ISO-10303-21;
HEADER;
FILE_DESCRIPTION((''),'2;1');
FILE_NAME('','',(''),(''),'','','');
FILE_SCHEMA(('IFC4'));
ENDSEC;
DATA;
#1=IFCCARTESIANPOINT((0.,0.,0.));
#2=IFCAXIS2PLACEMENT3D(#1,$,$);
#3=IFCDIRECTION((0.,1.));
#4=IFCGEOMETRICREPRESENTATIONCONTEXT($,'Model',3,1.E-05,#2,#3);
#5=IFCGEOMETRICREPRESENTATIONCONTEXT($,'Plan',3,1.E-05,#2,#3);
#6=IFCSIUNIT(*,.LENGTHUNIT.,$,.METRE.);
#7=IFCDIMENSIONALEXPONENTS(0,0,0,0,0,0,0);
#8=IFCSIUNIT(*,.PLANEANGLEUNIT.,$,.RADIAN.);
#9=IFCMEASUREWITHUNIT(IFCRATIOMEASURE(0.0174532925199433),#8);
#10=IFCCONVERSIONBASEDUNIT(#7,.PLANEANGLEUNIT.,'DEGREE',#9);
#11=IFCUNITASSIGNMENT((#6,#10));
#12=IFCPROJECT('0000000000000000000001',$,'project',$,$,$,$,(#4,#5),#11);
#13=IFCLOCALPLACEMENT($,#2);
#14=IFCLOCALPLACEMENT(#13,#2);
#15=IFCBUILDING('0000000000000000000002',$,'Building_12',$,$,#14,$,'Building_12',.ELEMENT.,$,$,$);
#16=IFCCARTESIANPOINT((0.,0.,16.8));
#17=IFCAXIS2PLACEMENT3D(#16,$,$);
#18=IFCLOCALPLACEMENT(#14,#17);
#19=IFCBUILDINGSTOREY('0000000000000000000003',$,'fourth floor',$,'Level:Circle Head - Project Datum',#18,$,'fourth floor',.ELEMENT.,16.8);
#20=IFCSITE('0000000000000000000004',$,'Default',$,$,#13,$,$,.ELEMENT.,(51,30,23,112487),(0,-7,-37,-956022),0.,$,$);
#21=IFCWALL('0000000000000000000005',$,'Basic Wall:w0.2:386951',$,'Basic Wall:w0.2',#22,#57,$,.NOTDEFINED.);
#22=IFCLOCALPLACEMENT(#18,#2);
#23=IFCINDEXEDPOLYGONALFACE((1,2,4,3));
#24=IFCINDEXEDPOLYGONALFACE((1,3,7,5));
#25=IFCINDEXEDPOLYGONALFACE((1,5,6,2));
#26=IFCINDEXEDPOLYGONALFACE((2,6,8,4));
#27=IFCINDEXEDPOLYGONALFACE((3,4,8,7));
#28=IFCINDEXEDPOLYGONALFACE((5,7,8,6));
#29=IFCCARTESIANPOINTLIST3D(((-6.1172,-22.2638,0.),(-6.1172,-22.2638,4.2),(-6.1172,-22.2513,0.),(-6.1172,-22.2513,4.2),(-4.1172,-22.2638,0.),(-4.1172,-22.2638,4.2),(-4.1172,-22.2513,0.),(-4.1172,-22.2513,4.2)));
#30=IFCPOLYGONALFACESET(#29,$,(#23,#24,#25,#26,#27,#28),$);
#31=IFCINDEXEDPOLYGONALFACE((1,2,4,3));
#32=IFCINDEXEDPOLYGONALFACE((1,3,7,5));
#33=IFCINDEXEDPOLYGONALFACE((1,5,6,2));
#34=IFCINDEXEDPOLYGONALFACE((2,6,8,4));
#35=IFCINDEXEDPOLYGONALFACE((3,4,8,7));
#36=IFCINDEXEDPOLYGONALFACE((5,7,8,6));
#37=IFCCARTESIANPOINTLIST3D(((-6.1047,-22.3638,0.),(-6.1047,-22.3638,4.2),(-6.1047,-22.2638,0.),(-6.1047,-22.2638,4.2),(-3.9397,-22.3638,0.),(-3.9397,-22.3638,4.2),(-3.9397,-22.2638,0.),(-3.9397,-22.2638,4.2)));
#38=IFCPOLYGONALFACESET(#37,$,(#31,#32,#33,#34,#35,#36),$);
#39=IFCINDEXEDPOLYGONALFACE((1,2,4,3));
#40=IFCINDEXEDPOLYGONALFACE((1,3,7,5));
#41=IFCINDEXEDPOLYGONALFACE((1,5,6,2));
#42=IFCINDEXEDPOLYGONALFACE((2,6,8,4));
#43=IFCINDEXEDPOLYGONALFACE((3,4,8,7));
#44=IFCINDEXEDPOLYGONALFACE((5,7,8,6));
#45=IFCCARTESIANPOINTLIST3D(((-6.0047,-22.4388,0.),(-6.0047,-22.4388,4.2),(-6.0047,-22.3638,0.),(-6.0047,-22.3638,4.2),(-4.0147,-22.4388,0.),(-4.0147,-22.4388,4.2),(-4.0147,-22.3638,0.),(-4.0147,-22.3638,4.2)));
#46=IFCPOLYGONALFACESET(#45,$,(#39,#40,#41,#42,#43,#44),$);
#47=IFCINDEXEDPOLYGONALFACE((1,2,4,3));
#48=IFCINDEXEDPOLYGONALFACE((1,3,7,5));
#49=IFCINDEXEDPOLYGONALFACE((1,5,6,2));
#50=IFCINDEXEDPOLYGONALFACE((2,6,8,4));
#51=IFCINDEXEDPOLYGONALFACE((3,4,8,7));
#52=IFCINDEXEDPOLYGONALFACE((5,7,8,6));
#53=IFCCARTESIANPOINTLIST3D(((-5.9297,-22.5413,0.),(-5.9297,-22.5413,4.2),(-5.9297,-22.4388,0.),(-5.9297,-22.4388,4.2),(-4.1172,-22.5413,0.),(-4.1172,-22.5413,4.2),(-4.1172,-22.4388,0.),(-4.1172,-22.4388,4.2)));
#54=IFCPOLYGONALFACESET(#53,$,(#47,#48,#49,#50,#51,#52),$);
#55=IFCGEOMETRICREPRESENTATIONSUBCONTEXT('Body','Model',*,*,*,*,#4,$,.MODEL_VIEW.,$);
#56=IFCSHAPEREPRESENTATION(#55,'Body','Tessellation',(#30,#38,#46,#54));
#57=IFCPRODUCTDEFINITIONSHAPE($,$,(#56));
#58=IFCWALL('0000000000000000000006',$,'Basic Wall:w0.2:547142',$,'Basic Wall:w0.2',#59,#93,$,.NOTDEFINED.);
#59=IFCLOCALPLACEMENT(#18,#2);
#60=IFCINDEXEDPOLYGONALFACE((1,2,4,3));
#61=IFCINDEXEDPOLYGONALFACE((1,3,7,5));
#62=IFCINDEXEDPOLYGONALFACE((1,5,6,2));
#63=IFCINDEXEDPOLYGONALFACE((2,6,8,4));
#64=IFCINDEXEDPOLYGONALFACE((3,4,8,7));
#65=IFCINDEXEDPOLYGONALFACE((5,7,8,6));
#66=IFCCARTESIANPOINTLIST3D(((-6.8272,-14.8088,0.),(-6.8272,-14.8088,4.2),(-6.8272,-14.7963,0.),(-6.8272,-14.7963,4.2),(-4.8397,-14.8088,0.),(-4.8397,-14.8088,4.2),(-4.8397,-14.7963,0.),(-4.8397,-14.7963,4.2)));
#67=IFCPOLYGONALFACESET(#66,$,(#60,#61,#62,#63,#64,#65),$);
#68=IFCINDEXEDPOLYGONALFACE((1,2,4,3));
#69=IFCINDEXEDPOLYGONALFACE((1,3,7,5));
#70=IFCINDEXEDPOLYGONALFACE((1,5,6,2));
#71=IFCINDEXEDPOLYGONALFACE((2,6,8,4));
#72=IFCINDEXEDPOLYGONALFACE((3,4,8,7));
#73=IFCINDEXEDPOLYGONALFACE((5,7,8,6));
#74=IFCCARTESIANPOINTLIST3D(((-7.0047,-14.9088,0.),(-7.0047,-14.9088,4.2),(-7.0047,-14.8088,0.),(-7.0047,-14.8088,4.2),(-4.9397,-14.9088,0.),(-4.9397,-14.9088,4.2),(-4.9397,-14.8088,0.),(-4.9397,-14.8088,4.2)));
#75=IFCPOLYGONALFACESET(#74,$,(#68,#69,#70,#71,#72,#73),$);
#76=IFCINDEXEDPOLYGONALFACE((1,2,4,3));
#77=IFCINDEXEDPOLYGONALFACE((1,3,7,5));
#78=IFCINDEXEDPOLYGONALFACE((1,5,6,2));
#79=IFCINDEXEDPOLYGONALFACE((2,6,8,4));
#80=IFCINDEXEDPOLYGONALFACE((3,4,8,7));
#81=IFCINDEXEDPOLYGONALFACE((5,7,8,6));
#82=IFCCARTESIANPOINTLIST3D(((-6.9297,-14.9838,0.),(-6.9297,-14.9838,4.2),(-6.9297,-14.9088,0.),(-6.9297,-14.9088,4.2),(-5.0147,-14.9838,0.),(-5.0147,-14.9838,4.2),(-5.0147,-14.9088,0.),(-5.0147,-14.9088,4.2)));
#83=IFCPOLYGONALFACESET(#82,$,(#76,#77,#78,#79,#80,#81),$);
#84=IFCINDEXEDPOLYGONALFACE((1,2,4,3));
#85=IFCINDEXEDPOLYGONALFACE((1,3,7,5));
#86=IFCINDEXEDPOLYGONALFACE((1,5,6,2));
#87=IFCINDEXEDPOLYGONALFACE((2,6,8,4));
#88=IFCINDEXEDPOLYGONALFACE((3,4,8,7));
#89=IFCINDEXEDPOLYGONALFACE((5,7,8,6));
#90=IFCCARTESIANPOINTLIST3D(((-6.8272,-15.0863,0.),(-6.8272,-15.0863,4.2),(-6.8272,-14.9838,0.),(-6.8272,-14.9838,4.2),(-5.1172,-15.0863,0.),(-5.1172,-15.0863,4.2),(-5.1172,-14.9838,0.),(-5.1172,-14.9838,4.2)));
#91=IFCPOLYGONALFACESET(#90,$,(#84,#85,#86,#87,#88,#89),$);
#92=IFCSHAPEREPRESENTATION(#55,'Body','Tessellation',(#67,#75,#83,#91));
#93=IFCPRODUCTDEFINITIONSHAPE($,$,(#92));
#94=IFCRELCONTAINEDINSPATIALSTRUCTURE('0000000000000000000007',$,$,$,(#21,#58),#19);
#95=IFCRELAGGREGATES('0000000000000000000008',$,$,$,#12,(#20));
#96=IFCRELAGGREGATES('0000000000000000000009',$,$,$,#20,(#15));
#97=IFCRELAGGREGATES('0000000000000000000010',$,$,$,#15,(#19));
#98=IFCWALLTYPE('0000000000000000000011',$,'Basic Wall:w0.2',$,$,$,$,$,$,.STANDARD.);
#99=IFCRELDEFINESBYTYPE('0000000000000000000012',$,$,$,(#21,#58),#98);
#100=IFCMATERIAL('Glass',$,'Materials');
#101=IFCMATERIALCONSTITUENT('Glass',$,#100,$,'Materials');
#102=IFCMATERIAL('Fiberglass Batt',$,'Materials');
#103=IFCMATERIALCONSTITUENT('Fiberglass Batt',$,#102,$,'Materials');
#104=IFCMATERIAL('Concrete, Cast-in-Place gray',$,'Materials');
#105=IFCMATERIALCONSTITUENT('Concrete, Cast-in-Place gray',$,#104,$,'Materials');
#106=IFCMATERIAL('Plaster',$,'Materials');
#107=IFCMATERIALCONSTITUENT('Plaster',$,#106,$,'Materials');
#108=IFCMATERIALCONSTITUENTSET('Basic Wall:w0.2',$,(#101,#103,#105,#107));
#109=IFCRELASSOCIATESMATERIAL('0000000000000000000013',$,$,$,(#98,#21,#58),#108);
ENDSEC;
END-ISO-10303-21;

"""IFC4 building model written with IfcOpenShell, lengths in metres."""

from ifc_helpers import new_model, entity, si_unit, converted_unit, direction, frame, origin, place, context, subcontext, project, spatial, indexed_curve, outline, extrude, material, constituent, constituent_set, type_object, element, save


model = new_model("IFC4")

# Units and contexts
model_context = context("Model", 3, precision=1e-05, world=origin(), true_north=direction((0.0, 1.0)))
plan_context = context("Plan", 3, precision=1e-05, world=origin(), true_north=direction((0.0, 1.0)))
body_context = subcontext(model_context, "Body", "Model", "MODEL_VIEW")
ifc_project = project(units=[si_unit("LENGTHUNIT", "METRE"), converted_unit("PLANEANGLEUNIT", "DEGREE", entity("IfcRatioMeasure", 0.0174532925199433), si_unit("PLANEANGLEUNIT", "RADIAN"), dimensions=[0, 0, 0, 0, 0, 0, 0])], contexts=[model_context, plan_context])

# Site, building, storey
site_placement = place(None, origin())
site = spatial("IfcSite", under=ifc_project, at=site_placement, Name="Default", CompositionType="ELEMENT", RefLatitude=(51, 30, 23, 112487), RefLongitude=(0, -7, -37, -956022), RefElevation=0.0)
building_placement = place(site_placement, origin())
building = spatial("IfcBuilding", under=site, at=building_placement, Name="Building_12", LongName="Building_12", CompositionType="ELEMENT")
storey_placement = place(building_placement, frame((0.0, 0.0, 16.8)))
storey = spatial("IfcBuildingStorey", under=building, at=storey_placement, Name="fourth floor", ObjectType="Level:Circle Head - Project Datum", LongName="fourth floor", CompositionType="ELEMENT", Elevation=16.8)

# Shared definitions
ifc_material_1 = material(Name="Glass", Category="Materials")
ifc_constituent_1 = constituent(ifc_material_1, Name="Glass", Category="Materials")
ifc_material_2 = material(Name="Fiberglass Batt", Category="Materials")
ifc_constituent_2 = constituent(ifc_material_2, Name="Fiberglass Batt", Category="Materials")
ifc_material_3 = material(Name="Concrete, Cast-in-Place gray", Category="Materials")
ifc_constituent_3 = constituent(ifc_material_3, Name="Concrete, Cast-in-Place gray", Category="Materials")
ifc_material_4 = material(Name="Plaster", Category="Materials")
ifc_constituent_4 = constituent(ifc_material_4, Name="Plaster", Category="Materials")
ifc_constituent_set_1 = constituent_set(constituents=[ifc_constituent_1, ifc_constituent_2, ifc_constituent_3, ifc_constituent_4], Name="Basic Wall:w0.2")
wall_type = type_object("IfcWallType", Name="Basic Wall:w0.2", PredefinedType="STANDARD", material=ifc_constituent_set_1)

# Wall, opening
wall_1_placement = place(storey_placement, frame((-4.1172, -22.3963, 0.0), z_axis=(0.0, 0.0, 1.0), x_axis=(-1.0, 0.0, 0.0)))
wall_1 = element("IfcWall", 1, at=wall_1_placement, inside=storey, type_object=wall_type, material=ifc_constituent_set_1, Name="Basic Wall:w0.2:386951", ObjectType="Basic Wall:w0.2", PredefinedType="NOTDEFINED", context=body_context, shape_type="SweptSolid", body=[
    extrude(outline(indexed_curve([(-0.0063, -1.0), (0.0062, -1.0), (0.0063, 1.0), (-0.0062, 1.0), (-0.0063, -1.0)], self_intersect=False)), frame((1.0, -0.1387, 0.0), z_axis=(0.0, 0.0, 1.0), x_axis=(0.0, 1.0, 0.0)), (0.0, 0.0, 1.0), 4.2),
    extrude(outline(indexed_curve([(-1.0825, -0.05), (1.0825, -0.05), (1.0825, 0.05), (-1.0825, 0.05), (-1.0825, -0.05)], self_intersect=False)), frame((0.905, -0.0825, 0.0)), (0.0, 0.0, 1.0), 4.2),
    extrude(outline(indexed_curve([(-0.995, -0.0375), (0.995, -0.0375), (0.995, 0.0375), (-0.995, 0.0375), (-0.995, -0.0375)], self_intersect=False)), frame((0.8925, 0.005, 0.0)), (0.0, 0.0, 1.0), 4.2),
    extrude(outline(indexed_curve([(-0.0513, -0.9063), (0.0512, -0.9063), (0.0513, 0.9063), (-0.0512, 0.9063), (-0.0513, -0.9063)], self_intersect=False)), frame((0.9063, 0.0938, 0.0), z_axis=(0.0, 0.0, 1.0), x_axis=(0.0, -1.0, 0.0)), (0.0, 0.0, 1.0), 4.2),
])
opening_1_placement = place(wall_1_placement, origin())
element("IfcOpeningElement", 2, at=opening_1_placement, cuts=wall_1, PredefinedType="OPENING", context=body_context, shape_type="SweptSolid", body=[
    extrude(outline(indexed_curve([(-0.145, -1.055), (0.145, -1.055), (0.145, 1.055), (-0.145, 1.055), (-0.145, -1.055)], self_intersect=False)), frame((1.855, 0.145, 1.055), z_axis=(0.0, 1.0, 0.0), x_axis=(-1.0, 0.0, 0.0)), (0.0, 0.0, 1.0), 0.91),
])

# Wall
wall_2_placement = place(storey_placement, frame((-5.1172, -14.9413, 0.0), z_axis=(0.0, 0.0, 1.0), x_axis=(-1.0, 0.0, 0.0)))
element("IfcWall", 3, at=wall_2_placement, inside=storey, type_object=wall_type, material=ifc_constituent_set_1, Name="Basic Wall:w0.2:547142", ObjectType="Basic Wall:w0.2", PredefinedType="NOTDEFINED", context=body_context, shape_type="SweptSolid", body=[
    extrude(outline(indexed_curve([(-0.0063, -0.9938), (0.0062, -0.9938), (0.0063, 0.9938), (-0.0062, 0.9938), (-0.0063, -0.9938)], self_intersect=False)), frame((0.7163, -0.1388, 0.0), z_axis=(0.0, 0.0, 1.0), x_axis=(0.0, 1.0, 0.0)), (0.0, 0.0, 1.0), 4.2),
    extrude(outline(indexed_curve([(-1.0325, -0.05), (1.0325, -0.05), (1.0325, 0.05), (-1.0325, 0.05), (-1.0325, -0.05)], self_intersect=False)), frame((0.855, -0.0825, 0.0)), (0.0, 0.0, 1.0), 4.2),
    extrude(outline(indexed_curve([(-0.9575, -0.0375), (0.9575, -0.0375), (0.9575, 0.0375), (-0.9575, 0.0375), (-0.9575, -0.0375)], self_intersect=False)), frame((0.855, 0.005, 0.0)), (0.0, 0.0, 1.0), 4.2),
    extrude(outline(indexed_curve([(-0.0513, -0.855), (0.0512, -0.855), (0.0513, 0.855), (-0.0512, 0.855), (-0.0513, -0.855)], self_intersect=False)), frame((0.855, 0.0937, 0.0), z_axis=(0.0, 0.0, 1.0), x_axis=(0.0, -1.0, 0.0)), (0.0, 0.0, 1.0), 4.2),
])

save(model, "model.ifc")
